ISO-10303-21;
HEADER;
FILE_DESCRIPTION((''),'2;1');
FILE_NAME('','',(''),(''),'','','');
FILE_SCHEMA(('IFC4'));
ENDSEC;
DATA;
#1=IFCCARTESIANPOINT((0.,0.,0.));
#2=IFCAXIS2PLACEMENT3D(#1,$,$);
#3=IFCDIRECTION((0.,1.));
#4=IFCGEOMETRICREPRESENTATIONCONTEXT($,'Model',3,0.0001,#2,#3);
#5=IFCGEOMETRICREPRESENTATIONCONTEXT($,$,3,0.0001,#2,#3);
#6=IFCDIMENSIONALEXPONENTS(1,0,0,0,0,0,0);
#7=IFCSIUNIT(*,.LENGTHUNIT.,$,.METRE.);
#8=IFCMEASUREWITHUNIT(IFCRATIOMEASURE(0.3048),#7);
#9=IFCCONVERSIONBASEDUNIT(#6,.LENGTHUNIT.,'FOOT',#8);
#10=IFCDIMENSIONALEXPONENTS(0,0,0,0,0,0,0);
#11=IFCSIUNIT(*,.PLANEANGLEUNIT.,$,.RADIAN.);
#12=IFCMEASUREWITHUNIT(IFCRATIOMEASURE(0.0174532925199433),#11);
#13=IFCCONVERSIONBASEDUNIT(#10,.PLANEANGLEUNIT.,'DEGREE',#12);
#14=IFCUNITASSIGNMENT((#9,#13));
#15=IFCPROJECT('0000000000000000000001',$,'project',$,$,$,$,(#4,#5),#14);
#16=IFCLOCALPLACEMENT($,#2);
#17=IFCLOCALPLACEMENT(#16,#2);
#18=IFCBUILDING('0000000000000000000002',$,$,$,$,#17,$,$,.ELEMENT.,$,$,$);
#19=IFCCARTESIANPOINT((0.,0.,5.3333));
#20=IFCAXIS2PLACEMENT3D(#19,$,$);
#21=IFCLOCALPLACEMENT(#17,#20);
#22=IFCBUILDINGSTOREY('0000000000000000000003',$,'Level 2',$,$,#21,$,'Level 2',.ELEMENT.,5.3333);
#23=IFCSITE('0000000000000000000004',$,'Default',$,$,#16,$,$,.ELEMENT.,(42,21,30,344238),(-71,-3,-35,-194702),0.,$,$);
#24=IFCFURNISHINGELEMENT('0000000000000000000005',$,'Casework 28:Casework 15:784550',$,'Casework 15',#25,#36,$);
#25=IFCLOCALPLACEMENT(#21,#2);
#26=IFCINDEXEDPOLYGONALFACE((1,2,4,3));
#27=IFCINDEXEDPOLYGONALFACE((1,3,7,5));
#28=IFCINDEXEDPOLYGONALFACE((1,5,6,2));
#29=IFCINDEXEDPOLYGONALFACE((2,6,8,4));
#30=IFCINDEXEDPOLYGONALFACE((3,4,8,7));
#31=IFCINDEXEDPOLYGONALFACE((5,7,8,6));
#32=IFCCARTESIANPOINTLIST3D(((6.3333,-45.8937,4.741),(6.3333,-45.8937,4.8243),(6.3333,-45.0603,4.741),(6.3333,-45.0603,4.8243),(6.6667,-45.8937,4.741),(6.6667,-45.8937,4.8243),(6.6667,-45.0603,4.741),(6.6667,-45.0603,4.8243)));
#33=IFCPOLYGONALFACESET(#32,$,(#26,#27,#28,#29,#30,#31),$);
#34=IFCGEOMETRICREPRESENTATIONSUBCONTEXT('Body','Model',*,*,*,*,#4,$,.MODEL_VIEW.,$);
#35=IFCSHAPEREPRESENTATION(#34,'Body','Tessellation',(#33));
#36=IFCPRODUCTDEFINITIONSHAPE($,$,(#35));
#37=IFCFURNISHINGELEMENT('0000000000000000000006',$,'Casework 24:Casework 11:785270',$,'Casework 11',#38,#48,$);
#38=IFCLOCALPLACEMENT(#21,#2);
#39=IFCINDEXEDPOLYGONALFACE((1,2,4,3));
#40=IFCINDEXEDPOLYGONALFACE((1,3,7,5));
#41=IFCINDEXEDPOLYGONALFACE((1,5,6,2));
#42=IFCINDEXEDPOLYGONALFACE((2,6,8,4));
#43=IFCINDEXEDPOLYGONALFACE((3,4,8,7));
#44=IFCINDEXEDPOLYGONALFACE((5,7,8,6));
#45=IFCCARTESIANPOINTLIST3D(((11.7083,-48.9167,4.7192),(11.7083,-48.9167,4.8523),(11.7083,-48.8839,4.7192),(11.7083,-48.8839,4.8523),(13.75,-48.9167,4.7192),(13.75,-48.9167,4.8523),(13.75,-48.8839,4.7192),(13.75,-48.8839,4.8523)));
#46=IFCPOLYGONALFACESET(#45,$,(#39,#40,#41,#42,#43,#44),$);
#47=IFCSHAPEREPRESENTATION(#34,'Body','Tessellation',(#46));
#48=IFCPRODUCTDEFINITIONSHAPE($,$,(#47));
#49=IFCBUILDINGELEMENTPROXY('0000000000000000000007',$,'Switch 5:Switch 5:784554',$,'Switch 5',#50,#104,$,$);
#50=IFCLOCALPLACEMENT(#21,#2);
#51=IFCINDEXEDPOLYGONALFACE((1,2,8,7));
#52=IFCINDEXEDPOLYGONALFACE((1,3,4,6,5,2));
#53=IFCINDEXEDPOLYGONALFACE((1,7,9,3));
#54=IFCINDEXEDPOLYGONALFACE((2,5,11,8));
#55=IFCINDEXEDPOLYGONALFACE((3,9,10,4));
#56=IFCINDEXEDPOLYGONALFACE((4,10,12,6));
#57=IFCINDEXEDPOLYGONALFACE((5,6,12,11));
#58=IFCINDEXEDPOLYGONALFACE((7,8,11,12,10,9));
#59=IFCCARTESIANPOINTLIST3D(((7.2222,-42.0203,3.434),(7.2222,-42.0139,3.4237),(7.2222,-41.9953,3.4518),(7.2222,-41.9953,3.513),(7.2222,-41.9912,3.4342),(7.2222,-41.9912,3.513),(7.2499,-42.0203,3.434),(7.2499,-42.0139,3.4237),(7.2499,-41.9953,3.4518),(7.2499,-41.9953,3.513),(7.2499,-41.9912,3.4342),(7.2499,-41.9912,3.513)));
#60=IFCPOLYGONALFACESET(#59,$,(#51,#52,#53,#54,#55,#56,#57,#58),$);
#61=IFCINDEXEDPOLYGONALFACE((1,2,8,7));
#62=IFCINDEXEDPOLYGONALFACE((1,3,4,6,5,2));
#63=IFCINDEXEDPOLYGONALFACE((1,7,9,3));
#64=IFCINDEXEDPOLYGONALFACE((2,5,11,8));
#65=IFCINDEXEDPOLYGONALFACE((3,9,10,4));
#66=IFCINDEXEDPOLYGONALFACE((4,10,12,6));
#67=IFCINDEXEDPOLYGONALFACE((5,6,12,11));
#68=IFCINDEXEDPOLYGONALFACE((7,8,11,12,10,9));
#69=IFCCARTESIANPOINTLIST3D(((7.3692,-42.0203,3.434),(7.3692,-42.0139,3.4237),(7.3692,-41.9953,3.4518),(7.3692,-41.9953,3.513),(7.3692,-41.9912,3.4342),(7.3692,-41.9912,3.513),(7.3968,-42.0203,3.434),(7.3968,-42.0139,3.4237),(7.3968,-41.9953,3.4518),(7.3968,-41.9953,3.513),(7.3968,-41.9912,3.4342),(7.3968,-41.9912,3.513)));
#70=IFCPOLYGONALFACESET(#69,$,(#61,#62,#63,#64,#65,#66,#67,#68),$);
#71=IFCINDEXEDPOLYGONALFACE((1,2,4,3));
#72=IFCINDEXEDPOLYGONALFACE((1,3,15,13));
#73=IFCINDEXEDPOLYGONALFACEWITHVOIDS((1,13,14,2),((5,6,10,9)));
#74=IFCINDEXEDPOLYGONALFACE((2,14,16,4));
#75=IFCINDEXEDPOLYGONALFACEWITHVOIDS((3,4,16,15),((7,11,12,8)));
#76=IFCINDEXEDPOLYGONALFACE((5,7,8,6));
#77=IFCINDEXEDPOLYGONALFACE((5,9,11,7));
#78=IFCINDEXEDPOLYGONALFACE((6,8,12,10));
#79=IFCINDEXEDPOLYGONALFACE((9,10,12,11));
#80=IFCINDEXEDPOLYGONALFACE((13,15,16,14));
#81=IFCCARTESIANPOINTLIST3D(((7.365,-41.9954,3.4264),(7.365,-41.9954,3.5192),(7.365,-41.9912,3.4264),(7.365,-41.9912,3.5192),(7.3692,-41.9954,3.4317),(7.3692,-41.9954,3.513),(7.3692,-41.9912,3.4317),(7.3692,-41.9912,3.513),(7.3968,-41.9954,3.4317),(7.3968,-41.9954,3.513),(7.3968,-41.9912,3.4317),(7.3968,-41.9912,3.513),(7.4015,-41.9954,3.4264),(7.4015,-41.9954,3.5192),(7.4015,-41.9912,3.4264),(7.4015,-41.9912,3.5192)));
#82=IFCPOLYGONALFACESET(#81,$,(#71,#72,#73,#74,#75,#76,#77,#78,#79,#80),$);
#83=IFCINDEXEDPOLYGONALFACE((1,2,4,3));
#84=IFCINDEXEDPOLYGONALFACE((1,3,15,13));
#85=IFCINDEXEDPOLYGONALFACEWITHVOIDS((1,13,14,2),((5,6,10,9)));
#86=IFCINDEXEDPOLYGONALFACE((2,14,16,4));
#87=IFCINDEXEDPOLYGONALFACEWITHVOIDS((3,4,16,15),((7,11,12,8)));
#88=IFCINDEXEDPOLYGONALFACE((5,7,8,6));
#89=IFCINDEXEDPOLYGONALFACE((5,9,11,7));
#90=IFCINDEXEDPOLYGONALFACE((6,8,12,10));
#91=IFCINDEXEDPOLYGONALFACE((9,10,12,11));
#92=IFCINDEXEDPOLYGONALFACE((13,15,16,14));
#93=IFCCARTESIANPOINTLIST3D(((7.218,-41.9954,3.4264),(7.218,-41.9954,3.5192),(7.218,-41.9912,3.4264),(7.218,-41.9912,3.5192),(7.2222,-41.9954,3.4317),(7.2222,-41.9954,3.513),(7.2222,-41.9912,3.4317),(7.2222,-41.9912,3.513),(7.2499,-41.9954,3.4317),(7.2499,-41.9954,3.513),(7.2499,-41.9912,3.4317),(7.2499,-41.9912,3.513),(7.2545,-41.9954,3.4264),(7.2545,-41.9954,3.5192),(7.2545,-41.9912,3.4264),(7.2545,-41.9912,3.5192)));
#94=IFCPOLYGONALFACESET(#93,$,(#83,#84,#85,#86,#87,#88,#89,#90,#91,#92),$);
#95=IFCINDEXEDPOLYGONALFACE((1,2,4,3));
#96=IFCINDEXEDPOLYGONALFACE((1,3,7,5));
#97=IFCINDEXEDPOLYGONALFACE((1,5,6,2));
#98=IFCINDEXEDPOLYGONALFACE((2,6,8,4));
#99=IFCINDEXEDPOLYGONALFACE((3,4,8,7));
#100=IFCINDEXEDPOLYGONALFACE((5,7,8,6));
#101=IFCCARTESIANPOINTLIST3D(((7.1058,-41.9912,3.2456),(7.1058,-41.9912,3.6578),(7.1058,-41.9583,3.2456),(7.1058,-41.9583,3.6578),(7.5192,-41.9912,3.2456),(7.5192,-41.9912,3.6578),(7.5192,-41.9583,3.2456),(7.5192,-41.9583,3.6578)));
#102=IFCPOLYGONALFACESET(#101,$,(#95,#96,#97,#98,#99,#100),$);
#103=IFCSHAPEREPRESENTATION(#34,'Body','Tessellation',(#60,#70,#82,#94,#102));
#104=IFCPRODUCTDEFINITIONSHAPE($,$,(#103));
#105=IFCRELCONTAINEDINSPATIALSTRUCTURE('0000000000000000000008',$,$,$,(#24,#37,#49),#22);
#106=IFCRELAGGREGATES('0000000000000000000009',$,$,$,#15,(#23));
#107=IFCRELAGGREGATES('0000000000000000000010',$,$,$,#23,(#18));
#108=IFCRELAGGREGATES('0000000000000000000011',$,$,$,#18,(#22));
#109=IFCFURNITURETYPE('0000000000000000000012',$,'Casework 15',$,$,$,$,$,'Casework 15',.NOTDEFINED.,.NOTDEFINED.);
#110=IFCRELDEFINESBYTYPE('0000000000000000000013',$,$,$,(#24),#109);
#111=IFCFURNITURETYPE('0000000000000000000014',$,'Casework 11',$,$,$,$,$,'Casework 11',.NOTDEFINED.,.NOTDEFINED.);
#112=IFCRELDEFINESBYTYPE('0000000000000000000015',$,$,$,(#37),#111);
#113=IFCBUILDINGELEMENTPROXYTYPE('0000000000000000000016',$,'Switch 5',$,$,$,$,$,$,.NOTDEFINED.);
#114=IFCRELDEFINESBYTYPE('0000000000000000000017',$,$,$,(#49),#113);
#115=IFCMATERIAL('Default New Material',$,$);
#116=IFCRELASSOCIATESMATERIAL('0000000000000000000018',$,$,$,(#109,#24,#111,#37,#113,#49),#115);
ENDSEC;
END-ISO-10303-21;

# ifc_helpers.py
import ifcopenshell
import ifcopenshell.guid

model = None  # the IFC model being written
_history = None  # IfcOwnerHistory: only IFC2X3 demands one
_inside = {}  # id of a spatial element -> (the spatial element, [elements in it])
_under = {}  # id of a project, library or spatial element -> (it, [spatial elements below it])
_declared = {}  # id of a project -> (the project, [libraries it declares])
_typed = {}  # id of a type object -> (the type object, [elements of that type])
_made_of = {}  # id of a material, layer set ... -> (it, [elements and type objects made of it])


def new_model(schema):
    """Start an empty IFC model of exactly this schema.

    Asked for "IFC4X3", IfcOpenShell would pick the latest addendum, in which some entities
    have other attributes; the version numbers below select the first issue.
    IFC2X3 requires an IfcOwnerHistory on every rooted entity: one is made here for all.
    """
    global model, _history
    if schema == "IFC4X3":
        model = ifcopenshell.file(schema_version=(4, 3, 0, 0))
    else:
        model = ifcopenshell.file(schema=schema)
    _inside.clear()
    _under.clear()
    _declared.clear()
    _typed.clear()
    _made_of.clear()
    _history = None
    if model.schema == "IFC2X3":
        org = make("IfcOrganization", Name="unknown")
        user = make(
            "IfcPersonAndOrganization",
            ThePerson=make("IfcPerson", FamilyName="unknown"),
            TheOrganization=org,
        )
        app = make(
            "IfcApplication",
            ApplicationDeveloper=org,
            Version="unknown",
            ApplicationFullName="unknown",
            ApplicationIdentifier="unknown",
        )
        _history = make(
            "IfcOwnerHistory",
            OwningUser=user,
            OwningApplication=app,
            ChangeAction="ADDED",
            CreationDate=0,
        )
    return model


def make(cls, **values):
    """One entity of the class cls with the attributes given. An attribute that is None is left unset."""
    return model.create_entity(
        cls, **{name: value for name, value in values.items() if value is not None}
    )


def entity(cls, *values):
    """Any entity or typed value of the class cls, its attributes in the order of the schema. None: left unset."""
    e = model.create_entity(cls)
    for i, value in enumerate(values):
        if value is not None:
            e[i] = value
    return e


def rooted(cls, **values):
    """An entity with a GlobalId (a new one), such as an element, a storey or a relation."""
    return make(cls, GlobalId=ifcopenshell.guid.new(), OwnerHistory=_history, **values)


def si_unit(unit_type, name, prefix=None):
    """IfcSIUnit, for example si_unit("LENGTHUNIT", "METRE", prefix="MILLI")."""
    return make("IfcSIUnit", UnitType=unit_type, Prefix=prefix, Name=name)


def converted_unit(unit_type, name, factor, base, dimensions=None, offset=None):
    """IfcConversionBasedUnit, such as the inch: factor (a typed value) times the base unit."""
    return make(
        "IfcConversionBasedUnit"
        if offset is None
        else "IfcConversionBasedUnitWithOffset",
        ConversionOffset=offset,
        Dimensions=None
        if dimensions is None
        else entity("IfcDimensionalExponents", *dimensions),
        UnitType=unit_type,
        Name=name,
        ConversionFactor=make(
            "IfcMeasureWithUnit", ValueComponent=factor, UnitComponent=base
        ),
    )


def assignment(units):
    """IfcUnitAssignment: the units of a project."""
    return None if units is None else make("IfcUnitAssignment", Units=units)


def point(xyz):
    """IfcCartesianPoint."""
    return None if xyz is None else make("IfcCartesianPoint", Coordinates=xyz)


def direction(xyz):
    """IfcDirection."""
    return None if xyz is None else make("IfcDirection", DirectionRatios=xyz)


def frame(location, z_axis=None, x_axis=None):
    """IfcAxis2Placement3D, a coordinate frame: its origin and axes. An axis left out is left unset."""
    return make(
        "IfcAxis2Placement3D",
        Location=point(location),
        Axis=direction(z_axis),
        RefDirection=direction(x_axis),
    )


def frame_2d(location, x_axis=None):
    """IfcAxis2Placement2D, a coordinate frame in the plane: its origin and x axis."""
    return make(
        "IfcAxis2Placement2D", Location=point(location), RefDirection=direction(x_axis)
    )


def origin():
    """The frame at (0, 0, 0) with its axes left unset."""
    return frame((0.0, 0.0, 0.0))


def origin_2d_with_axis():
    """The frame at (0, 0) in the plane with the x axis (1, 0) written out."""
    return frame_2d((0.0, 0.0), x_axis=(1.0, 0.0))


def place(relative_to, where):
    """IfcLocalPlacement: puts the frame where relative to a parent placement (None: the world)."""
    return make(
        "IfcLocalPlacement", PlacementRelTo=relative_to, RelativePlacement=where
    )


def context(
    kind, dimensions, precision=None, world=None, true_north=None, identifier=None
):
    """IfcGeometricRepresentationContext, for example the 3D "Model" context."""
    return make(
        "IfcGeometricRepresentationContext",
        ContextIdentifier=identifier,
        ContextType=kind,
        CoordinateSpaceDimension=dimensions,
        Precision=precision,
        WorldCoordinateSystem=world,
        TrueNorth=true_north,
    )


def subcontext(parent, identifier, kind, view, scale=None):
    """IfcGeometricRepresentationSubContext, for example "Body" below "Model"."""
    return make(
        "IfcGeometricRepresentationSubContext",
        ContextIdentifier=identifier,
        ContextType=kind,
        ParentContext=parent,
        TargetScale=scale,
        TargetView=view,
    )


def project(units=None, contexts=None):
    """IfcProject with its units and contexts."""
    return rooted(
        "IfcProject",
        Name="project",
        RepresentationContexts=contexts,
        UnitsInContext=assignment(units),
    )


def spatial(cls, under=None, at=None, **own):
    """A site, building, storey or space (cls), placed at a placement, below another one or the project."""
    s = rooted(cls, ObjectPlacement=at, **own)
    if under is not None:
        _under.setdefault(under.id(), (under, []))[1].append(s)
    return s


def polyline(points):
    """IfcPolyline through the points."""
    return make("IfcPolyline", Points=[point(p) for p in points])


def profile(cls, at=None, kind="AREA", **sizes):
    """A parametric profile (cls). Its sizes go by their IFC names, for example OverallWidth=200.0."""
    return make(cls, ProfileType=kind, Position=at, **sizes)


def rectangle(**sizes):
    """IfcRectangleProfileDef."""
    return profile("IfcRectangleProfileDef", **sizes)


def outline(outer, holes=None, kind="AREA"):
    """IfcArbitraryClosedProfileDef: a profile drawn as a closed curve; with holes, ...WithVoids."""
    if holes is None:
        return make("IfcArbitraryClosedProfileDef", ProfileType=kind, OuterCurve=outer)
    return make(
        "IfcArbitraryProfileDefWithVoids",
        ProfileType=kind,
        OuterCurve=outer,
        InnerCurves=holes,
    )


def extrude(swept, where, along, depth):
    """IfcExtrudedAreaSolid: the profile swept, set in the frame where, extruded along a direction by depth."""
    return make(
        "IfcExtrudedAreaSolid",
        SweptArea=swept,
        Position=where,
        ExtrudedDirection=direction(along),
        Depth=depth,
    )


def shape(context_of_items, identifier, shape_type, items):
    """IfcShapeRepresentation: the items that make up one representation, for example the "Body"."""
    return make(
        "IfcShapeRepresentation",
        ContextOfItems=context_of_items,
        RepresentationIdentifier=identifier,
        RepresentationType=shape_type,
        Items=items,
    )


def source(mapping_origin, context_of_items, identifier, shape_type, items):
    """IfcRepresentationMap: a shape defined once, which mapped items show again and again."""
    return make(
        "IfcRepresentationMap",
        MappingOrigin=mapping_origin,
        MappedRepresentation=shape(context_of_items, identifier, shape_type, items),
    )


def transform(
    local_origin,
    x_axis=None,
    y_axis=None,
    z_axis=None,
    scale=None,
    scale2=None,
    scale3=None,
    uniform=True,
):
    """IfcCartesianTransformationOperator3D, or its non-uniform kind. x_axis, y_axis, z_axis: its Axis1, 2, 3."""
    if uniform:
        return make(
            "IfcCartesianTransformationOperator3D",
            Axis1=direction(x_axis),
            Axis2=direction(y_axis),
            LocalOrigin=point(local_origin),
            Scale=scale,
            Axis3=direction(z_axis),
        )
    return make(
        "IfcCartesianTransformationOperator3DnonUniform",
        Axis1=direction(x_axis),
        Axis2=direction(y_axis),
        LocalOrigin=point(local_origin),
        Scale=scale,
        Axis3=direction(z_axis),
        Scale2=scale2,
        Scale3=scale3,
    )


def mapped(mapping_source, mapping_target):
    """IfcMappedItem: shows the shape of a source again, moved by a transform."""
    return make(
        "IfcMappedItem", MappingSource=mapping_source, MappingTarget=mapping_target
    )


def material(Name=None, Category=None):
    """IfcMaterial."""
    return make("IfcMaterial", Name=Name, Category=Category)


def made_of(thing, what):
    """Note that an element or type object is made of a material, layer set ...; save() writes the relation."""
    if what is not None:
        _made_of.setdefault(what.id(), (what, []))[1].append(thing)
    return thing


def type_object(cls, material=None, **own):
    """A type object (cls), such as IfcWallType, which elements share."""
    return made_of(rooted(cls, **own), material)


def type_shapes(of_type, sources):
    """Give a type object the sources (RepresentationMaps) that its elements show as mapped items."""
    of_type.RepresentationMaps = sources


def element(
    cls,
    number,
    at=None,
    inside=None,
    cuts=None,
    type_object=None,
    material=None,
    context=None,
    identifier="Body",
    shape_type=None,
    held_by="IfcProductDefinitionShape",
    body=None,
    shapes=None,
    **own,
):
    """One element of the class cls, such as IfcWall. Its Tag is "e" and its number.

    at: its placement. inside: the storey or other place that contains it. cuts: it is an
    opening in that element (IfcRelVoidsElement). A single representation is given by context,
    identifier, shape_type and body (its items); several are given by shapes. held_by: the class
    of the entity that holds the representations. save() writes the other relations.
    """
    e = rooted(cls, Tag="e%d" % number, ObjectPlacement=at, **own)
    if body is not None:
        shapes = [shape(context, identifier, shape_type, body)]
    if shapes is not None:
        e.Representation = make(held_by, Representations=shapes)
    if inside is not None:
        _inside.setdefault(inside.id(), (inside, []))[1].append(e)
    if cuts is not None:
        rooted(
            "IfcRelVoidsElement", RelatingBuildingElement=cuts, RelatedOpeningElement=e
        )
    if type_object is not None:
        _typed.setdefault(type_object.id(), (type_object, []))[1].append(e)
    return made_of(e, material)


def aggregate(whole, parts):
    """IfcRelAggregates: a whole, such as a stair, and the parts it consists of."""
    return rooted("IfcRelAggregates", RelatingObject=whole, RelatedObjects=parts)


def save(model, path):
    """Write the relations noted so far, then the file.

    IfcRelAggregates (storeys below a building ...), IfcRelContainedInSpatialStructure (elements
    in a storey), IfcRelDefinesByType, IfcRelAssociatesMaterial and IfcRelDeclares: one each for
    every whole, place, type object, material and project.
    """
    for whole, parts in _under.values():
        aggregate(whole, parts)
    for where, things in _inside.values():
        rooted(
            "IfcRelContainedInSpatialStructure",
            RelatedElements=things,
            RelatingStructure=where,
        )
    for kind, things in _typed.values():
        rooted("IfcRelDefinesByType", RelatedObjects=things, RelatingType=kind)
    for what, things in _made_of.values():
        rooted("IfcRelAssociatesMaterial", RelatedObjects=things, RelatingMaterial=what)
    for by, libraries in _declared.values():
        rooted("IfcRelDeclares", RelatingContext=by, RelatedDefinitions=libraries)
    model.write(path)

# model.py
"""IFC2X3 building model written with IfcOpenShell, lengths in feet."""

from ifc_helpers import new_model, entity, si_unit, converted_unit, direction, frame, frame_2d, origin, origin_2d_with_axis, place, context, subcontext, project, spatial, polyline, rectangle, outline, extrude, source, transform, mapped, material, type_object, type_shapes, element, save


model = new_model("IFC2X3")

# Units and contexts
model_context = context("Model", 3, precision=0.0001, world=origin(), true_north=direction((0.0, 1.0)))
context_of_model = context(None, 3, precision=0.0001, world=origin(), true_north=direction((0.0, 1.0)))
body_context = subcontext(model_context, "Body", "Model", "MODEL_VIEW")
ifc_project = project(units=[converted_unit("LENGTHUNIT", "FOOT", entity("IfcRatioMeasure", 0.3048), si_unit("LENGTHUNIT", "METRE"), dimensions=[1, 0, 0, 0, 0, 0, 0]), converted_unit("PLANEANGLEUNIT", "DEGREE", entity("IfcRatioMeasure", 0.0174532925199433), si_unit("PLANEANGLEUNIT", "RADIAN"), dimensions=[0, 0, 0, 0, 0, 0, 0])], contexts=[model_context, context_of_model])

# Site, building, storey
site_placement = place(None, origin())
site = spatial("IfcSite", under=ifc_project, at=site_placement, Name="Default", CompositionType="ELEMENT", RefLatitude=(42, 21, 30, 344238), RefLongitude=(-71, -3, -35, -194702), RefElevation=0.0)
building_placement = place(site_placement, origin())
building = spatial("IfcBuilding", under=site, at=building_placement, CompositionType="ELEMENT")
storey_placement = place(building_placement, frame((0.0, 0.0, 5.3333)))
storey = spatial("IfcBuildingStorey", under=building, at=storey_placement, Name="Level 2", LongName="Level 2", CompositionType="ELEMENT", Elevation=5.3333)

# Shared definitions
ifc_material = material(Name="Default New Material")

# Furnishing elements
furniture_type_1 = type_object("IfcFurnitureType", Name="Casework 15", ElementType="Casework 15", AssemblyPlace="NOTDEFINED", material=ifc_material)
shared_shape_1 = source(origin(), body_context, "Body", "SweptSolid", [
    extrude(rectangle(XDim=0.3333, YDim=0.8333, at=frame_2d((0.0, 0.0), x_axis=(1.0, 0.0))), frame((0.1667, 0.4167, 0.0), z_axis=(0.0, 0.0, 1.0), x_axis=(-1.0, 0.0, 0.0)), (0.0, 0.0, 1.0), 0.0833),
])
type_shapes(furniture_type_1, [shared_shape_1])
furnishing_1_placement = place(storey_placement, frame((6.3333, -45.8937, 4.741)))
element("IfcFurnishingElement", 1, at=furnishing_1_placement, inside=storey, type_object=furniture_type_1, material=ifc_material, Name="Casework 28:Casework 15:784550", ObjectType="Casework 15", context=body_context, shape_type="MappedRepresentation", body=[
    mapped(shared_shape_1, transform((0.0, 0.0, 0.0), scale=1.0)),
])
furniture_type_2 = type_object("IfcFurnitureType", Name="Casework 11", ElementType="Casework 11", AssemblyPlace="NOTDEFINED", material=ifc_material)
shared_shape_2 = source(origin(), body_context, "Body", "SweptSolid", [
    extrude(rectangle(XDim=0.0328, YDim=2.0417, at=origin_2d_with_axis()), frame((1.0208, 0.0164, 0.0), z_axis=(0.0, 0.0, 1.0), x_axis=(0.0, -1.0, 0.0)), (0.0, 0.0, 1.0), 0.1331),
])
type_shapes(furniture_type_2, [shared_shape_2])
furnishing_2_placement = place(storey_placement, frame((11.7083, -48.9167, 4.7192)))
element("IfcFurnishingElement", 2, at=furnishing_2_placement, inside=storey, type_object=furniture_type_2, material=ifc_material, Name="Casework 24:Casework 11:785270", ObjectType="Casework 11", context=body_context, shape_type="MappedRepresentation", body=[
    mapped(shared_shape_2, transform((0.0, 0.0, 0.0), scale=1.0)),
])

# Building element proxy
building_element_proxy_type_1 = type_object("IfcBuildingElementProxyType", Name="Switch 5", PredefinedType="NOTDEFINED", material=ifc_material)
shared_shape_3 = source(origin(), body_context, "Body", "SweptSolid", [
    extrude(outline(polyline([(-0.0255, -0.0308), (-0.0133, -0.0308), (-0.0115, -0.0002), (0.0405, 0.0322), (0.0383, 0.0356), (-0.0285, -0.006), (-0.0255, -0.0308)])), frame((0.0626, 0.0429, 0.216), z_axis=(1.0, 0.0, 0.0), x_axis=(0.0, 0.528865, 0.848706)), (0.0, 0.0, 1.0), 0.0277),
    extrude(outline(polyline([(-0.0255, -0.0308), (-0.0133, -0.0308), (-0.0115, -0.0002), (0.0405, 0.0322), (0.0383, 0.0356), (-0.0285, -0.006), (-0.0255, -0.0308)])), frame((-0.0843, 0.0429, 0.216), z_axis=(1.0, 0.0, 0.0), x_axis=(0.0, 0.528865, 0.848706)), (0.0, 0.0, 1.0), 0.0277),
    extrude(outline(polyline([(-0.0464, -0.0182), (0.0464, -0.0182), (0.0464, 0.0182), (-0.0464, 0.0182), (-0.0464, -0.0182)]), holes=[polyline([(-0.0402, -0.0141), (-0.0402, 0.0136), (0.0411, 0.0136), (0.0411, -0.0141), (-0.0402, -0.0141)])]), frame((-0.0707, 0.0329, 0.2271), z_axis=(0.0, 1.0, 0.0), x_axis=(0.0, 0.0, -1.0)), (0.0, 0.0, 1.0), 0.0042),
    extrude(outline(polyline([(-0.0464, -0.0182), (0.0464, -0.0182), (0.0464, 0.0182), (-0.0464, 0.0182), (-0.0464, -0.0182)]), holes=[polyline([(-0.0402, -0.0141), (-0.0402, 0.0136), (0.0411, 0.0136), (0.0411, -0.0141), (-0.0402, -0.0141)])]), frame((0.0762, 0.0329, 0.2271), z_axis=(0.0, 1.0, 0.0), x_axis=(0.0, 0.0, -1.0)), (0.0, 0.0, 1.0), 0.0042),
    extrude(rectangle(XDim=0.0329, YDim=0.4134, at=origin_2d_with_axis()), frame((0.0, 0.0164, 0.0), z_axis=(0.0, 0.0, 1.0), x_axis=(0.0, -1.0, 0.0)), (0.0, 0.0, 1.0), 0.4121),
])
type_shapes(building_element_proxy_type_1, [shared_shape_3])
proxy_1_placement = place(storey_placement, frame((7.3125, -41.9583, 3.2456), z_axis=(0.0, 0.0, 1.0), x_axis=(-1.0, 0.0, 0.0)))
element("IfcBuildingElementProxy", 3, at=proxy_1_placement, inside=storey, type_object=building_element_proxy_type_1, material=ifc_material, Name="Switch 5:Switch 5:784554", ObjectType="Switch 5", context=body_context, shape_type="MappedRepresentation", body=[
    mapped(shared_shape_3, transform((0.0, 0.0, 0.0), scale=1.0)),
])

save(model, "model.ifc")
